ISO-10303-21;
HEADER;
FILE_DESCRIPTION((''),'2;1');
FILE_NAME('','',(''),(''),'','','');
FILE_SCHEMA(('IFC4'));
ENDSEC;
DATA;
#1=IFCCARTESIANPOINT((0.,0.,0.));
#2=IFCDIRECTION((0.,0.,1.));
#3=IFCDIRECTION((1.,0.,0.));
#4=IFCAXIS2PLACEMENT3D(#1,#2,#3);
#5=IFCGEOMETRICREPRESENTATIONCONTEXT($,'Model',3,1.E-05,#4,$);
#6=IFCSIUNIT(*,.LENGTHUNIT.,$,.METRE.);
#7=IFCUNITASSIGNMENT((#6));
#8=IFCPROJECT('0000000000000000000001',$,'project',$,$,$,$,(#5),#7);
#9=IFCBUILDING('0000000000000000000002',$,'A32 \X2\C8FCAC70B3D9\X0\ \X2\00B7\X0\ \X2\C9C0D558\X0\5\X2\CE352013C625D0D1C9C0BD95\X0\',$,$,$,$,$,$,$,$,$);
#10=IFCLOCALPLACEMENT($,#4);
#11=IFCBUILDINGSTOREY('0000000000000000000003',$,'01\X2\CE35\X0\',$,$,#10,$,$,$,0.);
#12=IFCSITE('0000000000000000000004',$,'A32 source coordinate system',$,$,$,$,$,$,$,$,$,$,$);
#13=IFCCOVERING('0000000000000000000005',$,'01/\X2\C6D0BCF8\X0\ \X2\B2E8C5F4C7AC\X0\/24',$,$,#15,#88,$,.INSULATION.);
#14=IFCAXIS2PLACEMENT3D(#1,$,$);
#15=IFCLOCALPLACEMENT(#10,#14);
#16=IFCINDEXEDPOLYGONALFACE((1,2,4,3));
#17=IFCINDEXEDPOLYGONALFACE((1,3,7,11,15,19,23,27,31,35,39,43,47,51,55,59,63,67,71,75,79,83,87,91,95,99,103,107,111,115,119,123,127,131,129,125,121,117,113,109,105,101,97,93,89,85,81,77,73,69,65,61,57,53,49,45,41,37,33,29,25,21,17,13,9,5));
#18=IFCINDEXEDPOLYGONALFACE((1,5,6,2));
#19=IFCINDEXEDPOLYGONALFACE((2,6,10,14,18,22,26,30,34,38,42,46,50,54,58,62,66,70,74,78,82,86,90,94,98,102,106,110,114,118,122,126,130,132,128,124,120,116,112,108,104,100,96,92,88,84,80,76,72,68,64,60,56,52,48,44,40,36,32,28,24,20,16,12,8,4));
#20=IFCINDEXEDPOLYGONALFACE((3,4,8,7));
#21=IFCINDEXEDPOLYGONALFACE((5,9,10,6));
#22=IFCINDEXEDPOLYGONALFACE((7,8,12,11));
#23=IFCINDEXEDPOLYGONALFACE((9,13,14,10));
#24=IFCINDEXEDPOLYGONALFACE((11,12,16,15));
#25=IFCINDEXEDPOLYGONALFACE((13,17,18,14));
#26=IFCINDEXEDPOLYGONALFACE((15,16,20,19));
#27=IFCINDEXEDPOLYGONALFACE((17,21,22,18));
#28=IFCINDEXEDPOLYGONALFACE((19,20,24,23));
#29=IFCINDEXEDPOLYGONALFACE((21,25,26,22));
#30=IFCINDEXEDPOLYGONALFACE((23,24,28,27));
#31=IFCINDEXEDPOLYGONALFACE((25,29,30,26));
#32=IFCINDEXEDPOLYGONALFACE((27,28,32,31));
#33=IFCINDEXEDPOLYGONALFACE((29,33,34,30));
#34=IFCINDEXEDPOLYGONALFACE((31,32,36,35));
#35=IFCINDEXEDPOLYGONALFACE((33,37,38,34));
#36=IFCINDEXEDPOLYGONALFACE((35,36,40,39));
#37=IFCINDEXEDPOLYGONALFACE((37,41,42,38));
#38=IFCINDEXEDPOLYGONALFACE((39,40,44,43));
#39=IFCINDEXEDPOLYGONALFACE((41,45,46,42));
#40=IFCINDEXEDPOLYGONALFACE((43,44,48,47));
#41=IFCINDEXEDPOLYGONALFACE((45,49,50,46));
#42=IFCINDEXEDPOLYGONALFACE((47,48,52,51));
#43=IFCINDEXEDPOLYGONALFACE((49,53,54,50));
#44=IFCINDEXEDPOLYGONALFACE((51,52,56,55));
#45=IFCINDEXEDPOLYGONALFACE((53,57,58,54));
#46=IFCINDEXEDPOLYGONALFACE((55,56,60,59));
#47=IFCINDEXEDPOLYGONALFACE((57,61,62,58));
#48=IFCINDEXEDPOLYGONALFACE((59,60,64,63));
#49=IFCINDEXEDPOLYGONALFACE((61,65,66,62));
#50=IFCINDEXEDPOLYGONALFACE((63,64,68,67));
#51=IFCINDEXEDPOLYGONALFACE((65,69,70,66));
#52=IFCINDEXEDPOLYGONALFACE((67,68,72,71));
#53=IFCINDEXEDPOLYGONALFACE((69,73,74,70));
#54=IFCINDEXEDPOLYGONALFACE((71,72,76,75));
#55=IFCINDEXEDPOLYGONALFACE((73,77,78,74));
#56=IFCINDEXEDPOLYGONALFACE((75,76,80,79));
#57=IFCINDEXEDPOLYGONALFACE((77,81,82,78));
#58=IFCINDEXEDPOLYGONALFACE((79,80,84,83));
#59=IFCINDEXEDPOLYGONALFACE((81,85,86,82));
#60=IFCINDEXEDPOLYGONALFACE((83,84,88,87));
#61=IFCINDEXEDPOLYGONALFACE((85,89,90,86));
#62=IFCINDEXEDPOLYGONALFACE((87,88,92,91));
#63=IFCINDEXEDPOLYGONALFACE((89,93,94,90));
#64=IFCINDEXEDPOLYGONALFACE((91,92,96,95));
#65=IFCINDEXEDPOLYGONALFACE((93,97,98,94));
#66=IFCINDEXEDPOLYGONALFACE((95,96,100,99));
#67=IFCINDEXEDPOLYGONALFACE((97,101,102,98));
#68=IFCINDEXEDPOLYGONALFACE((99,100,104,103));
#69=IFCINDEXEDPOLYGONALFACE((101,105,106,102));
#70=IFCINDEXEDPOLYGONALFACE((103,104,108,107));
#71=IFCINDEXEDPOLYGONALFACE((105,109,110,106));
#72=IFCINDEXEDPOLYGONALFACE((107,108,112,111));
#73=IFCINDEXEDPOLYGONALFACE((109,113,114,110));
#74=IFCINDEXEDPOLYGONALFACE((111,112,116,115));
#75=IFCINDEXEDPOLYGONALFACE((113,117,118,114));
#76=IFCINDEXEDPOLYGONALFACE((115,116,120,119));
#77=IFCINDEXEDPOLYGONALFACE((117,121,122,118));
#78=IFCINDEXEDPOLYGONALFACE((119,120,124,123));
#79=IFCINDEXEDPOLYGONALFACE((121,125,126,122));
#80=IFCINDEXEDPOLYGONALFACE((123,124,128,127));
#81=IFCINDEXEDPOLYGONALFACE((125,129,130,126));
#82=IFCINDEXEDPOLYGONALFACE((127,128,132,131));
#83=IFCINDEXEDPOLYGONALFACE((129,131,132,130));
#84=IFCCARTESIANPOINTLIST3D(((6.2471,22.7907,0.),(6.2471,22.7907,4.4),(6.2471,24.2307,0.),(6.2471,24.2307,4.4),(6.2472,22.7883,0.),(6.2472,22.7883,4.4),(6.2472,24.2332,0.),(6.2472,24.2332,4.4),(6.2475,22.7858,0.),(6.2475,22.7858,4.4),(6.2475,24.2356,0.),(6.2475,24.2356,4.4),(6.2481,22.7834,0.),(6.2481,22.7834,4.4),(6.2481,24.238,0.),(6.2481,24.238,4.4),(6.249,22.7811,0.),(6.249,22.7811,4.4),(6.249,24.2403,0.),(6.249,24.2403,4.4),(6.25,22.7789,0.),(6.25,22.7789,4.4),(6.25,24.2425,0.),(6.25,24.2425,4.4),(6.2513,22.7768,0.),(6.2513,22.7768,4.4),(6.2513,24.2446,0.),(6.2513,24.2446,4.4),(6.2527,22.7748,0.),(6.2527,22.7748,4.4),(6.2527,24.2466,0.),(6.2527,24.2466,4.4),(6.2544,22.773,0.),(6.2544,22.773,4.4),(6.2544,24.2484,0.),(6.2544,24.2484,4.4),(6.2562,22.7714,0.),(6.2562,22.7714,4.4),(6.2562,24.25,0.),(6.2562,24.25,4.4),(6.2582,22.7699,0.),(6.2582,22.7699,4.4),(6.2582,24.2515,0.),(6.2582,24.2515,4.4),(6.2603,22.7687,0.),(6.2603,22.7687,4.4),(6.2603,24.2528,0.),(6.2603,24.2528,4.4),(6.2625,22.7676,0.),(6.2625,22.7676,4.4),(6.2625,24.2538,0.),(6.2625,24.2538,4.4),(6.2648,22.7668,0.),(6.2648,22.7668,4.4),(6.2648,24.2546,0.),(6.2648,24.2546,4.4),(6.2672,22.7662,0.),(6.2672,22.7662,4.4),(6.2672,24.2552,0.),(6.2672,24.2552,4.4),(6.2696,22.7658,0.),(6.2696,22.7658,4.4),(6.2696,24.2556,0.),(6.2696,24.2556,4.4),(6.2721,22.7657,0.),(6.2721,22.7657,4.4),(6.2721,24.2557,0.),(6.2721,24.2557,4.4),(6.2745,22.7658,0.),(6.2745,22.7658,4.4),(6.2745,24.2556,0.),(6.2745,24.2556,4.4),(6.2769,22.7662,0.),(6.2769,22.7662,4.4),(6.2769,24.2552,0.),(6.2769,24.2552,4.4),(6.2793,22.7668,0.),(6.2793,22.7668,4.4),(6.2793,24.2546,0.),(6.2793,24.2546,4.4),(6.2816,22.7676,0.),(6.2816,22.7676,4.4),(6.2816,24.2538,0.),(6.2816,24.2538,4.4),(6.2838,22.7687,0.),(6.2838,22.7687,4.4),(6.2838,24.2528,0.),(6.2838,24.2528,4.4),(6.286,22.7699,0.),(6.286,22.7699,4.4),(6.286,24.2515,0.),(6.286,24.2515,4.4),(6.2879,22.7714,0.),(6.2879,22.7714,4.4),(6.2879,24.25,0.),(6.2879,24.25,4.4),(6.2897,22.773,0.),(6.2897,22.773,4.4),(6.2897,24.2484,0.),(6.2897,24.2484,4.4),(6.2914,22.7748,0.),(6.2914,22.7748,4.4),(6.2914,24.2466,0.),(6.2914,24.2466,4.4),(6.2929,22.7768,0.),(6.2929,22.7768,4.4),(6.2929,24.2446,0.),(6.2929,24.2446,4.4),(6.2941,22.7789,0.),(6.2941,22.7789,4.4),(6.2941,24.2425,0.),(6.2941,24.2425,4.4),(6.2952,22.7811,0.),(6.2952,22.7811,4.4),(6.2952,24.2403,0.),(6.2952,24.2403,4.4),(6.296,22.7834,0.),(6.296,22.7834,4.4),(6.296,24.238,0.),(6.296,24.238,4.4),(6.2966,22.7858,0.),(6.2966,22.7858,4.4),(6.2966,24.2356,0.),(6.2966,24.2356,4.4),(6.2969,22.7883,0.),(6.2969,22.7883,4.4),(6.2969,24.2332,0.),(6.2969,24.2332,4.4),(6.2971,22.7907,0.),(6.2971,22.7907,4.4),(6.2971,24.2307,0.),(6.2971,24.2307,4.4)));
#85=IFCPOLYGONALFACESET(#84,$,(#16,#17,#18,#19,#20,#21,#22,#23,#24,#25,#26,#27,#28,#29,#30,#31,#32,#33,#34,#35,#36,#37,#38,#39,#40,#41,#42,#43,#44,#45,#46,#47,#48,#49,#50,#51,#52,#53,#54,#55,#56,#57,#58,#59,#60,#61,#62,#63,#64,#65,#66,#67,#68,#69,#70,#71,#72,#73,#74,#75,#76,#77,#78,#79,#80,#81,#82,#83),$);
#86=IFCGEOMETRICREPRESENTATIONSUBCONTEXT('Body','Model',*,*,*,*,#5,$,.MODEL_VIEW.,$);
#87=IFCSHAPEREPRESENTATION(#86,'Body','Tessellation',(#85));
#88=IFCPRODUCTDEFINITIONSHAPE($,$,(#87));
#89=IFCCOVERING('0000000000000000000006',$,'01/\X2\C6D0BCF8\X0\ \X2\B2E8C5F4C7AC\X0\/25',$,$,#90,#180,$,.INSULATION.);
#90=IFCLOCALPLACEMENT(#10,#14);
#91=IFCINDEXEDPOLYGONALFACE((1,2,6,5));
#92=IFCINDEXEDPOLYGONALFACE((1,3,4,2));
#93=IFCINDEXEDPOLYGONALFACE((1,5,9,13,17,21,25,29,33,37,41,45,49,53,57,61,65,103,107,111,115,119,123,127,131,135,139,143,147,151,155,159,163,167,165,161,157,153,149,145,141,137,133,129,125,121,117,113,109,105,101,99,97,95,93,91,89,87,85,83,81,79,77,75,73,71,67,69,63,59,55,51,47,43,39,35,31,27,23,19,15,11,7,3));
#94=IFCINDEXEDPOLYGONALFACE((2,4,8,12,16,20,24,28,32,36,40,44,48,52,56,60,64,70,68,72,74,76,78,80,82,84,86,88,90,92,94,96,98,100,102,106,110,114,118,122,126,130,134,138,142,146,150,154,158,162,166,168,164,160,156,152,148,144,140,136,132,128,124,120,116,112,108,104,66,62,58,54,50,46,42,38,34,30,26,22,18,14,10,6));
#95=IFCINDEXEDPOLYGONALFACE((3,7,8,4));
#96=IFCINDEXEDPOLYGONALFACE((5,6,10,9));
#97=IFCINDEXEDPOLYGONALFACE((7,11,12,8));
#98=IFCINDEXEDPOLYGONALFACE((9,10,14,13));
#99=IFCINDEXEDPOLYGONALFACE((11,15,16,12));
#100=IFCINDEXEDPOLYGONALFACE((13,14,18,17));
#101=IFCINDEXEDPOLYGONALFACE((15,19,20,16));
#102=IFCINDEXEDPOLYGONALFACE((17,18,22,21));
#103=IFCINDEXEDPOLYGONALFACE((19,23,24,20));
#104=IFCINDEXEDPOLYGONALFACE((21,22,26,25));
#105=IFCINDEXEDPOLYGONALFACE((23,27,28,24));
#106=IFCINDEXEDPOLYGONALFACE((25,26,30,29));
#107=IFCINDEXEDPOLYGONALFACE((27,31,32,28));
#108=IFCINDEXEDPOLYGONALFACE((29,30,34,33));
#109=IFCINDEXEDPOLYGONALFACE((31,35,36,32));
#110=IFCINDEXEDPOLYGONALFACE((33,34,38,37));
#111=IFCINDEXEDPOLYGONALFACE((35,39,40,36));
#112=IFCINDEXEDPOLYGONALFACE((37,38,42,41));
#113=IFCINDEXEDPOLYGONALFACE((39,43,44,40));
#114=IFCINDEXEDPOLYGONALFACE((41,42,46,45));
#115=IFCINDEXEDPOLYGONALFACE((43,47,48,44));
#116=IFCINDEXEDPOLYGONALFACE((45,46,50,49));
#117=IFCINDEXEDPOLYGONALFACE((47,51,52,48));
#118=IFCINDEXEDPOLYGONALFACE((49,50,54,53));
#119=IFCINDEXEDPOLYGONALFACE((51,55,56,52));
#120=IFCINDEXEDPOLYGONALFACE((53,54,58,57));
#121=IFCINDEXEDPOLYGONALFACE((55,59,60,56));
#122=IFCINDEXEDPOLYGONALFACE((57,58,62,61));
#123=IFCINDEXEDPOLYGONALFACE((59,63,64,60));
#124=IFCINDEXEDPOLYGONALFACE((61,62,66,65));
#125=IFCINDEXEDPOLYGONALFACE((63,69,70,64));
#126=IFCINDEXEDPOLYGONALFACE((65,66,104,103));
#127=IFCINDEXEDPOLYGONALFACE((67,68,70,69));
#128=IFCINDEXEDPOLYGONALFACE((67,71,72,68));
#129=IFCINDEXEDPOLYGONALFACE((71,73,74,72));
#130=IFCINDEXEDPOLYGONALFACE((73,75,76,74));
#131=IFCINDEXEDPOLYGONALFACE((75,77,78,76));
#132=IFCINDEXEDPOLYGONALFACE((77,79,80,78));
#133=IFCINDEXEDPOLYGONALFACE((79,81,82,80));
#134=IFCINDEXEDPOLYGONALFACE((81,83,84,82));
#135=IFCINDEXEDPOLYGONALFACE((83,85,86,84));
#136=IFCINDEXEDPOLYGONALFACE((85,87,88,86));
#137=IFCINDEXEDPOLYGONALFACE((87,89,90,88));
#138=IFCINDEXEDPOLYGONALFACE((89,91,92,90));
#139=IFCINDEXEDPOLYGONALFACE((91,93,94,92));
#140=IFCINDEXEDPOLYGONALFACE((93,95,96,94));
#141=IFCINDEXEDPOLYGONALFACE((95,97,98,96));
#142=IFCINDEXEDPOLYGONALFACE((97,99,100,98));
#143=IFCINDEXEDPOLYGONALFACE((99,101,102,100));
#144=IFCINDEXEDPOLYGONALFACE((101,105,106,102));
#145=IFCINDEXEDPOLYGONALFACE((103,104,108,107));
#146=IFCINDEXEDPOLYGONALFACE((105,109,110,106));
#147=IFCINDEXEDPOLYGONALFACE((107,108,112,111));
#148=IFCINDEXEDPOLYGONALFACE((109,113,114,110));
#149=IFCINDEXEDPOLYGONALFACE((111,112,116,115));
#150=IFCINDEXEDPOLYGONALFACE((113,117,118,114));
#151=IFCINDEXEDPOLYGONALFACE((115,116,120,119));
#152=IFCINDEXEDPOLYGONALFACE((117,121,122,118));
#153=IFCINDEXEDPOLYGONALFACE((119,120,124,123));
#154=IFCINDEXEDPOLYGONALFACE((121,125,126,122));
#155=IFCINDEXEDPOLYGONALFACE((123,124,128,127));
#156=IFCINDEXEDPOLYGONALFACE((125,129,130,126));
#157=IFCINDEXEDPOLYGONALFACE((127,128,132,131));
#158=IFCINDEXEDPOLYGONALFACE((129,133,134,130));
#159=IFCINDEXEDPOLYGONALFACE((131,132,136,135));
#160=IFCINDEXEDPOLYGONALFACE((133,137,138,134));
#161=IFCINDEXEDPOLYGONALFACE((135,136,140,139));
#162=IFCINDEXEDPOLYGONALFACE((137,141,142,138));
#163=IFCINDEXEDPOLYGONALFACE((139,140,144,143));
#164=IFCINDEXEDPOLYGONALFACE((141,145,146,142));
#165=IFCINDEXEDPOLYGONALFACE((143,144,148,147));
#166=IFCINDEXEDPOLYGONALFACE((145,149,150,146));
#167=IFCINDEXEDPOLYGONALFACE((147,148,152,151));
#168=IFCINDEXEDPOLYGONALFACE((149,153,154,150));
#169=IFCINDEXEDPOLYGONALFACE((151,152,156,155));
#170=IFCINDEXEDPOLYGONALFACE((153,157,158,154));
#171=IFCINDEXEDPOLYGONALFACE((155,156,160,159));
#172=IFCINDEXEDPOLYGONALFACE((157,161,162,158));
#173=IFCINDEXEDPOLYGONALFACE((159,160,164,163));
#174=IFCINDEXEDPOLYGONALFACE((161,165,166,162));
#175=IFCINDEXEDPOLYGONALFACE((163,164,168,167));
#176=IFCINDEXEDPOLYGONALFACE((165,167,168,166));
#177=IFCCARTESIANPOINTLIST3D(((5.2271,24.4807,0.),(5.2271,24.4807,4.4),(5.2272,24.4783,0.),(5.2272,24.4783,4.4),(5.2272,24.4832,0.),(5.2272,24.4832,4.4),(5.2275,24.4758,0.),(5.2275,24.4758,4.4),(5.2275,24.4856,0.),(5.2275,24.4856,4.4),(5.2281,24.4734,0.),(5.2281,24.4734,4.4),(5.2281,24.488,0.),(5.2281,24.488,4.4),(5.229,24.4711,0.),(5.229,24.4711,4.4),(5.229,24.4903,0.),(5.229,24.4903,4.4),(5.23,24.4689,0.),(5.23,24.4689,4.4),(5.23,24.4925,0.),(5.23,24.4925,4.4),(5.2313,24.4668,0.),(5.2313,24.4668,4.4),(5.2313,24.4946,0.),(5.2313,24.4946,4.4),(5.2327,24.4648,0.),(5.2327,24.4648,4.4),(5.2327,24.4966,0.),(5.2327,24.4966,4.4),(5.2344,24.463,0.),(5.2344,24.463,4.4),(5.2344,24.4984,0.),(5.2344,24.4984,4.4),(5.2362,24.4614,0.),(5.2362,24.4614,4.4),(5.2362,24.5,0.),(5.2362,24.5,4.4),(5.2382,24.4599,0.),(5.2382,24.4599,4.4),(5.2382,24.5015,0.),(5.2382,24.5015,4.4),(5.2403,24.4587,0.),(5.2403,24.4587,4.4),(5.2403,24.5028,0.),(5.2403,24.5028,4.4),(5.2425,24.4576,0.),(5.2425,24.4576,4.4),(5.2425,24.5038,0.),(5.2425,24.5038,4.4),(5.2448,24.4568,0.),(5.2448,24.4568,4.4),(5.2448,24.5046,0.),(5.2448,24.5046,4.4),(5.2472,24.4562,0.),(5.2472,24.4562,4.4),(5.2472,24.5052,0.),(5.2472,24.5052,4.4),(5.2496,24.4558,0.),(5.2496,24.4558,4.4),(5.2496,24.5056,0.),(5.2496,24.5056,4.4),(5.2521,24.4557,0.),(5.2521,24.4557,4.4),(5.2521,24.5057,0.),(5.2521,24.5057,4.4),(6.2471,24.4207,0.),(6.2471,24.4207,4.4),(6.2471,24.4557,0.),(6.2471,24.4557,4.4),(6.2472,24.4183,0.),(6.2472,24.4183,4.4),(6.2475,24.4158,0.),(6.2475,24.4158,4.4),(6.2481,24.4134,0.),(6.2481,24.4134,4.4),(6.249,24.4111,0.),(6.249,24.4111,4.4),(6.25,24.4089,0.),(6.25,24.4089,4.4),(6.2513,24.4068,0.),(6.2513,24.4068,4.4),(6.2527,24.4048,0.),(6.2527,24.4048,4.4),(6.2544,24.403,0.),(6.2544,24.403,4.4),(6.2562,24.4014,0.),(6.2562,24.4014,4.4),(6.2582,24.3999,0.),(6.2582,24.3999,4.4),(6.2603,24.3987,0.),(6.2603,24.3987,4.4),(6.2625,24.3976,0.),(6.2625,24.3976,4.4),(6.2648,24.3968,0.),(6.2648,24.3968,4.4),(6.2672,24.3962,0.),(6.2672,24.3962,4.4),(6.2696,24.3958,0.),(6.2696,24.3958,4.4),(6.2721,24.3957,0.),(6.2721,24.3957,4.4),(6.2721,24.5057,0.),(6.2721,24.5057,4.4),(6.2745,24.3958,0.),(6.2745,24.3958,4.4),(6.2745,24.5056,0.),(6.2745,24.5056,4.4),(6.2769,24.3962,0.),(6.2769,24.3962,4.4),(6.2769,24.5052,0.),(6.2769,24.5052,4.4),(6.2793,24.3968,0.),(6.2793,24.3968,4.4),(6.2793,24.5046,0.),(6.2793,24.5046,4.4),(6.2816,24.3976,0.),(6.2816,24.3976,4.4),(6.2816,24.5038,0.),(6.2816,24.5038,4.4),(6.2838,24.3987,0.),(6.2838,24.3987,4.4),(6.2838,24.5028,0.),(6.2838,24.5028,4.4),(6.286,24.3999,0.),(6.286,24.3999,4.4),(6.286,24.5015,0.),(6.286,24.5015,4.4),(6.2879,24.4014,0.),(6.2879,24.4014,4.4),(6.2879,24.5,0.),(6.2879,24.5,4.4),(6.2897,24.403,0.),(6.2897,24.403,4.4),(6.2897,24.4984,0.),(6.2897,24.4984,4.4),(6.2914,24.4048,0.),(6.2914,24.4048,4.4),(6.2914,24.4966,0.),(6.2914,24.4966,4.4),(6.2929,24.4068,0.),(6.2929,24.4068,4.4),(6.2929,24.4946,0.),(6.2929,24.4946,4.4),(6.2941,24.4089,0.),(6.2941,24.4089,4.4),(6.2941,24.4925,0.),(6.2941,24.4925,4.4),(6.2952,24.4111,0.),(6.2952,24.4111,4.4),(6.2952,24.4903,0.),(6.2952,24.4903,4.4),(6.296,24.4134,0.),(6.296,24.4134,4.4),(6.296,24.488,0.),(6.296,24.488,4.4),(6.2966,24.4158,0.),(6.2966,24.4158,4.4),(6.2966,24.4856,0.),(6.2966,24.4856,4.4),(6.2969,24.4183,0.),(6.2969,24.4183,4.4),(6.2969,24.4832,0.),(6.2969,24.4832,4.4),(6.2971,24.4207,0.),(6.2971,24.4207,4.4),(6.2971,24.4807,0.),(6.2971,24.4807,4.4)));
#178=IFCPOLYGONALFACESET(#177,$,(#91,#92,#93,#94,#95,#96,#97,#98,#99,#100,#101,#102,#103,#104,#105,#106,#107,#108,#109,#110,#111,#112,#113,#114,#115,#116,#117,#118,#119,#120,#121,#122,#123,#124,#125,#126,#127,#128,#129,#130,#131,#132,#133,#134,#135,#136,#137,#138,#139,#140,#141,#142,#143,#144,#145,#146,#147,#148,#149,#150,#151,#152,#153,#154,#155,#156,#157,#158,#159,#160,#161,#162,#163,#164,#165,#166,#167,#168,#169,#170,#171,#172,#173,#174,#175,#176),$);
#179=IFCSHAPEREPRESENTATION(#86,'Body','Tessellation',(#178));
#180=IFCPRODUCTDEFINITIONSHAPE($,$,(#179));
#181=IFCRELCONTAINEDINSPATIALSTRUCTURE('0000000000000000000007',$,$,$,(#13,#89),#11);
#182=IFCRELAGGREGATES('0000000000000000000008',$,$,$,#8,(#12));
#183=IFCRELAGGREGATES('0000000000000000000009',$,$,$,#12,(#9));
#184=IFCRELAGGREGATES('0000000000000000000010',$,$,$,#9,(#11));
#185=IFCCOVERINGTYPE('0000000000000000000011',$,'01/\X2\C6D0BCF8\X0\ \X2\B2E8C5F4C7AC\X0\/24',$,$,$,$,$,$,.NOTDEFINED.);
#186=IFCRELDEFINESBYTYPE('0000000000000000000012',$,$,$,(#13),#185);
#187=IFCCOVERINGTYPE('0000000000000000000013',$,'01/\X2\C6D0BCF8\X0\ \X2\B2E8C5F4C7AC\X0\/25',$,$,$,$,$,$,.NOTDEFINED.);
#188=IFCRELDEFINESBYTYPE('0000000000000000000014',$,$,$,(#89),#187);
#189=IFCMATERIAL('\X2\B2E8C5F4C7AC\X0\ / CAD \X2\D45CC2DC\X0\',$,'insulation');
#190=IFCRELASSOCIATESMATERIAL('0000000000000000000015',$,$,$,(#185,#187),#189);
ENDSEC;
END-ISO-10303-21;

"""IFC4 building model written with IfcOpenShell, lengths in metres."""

from ifc_helpers import new_model, si_unit, origin, origin_with_axes, place, context, subcontext, project, spatial, polyline, outline, extrude, source, transform, mapped, material, type_object, type_shapes, element, save


model = new_model("IFC4")

# Units and contexts
model_context = context("Model", 3, precision=1e-05, world=origin_with_axes())
body_context = subcontext(model_context, "Body", "Model", "MODEL_VIEW")
ifc_project = project(units=[si_unit("LENGTHUNIT", "METRE")], contexts=[model_context])

# Site, building, storey
site = spatial("IfcSite", under=ifc_project, Name="A32 source coordinate system")
building = spatial("IfcBuilding", under=site, Name="A32 주거동 · 지하5층–옥탑지붕")
storey_placement = place(None, origin_with_axes())
storey = spatial("IfcBuildingStorey", under=building, at=storey_placement, Name="01층", Elevation=0.0)

# Coverings
ifc_material = material(Name="단열재 / CAD 표시", Category="insulation")
covering_type_1 = type_object("IfcCoveringType", Name="01/원본 단열재/24", PredefinedType="NOTDEFINED", material=ifc_material)
shared_shape_1 = source(origin(), body_context, "Body", "SweptSolid", [
    extrude(outline(polyline([(6.2513, 24.2446), (6.2527, 24.2466), (6.2544, 24.2484), (6.2562, 24.25), (6.2582, 24.2515), (6.2603, 24.2528), (6.2625, 24.2538), (6.2648, 24.2546), (6.2672, 24.2552), (6.2696, 24.2556), (6.2721, 24.2557), (6.2745, 24.2556), (6.2769, 24.2552), (6.2793, 24.2546), (6.2816, 24.2538), (6.2838, 24.2528), (6.286, 24.2515), (6.2879, 24.25), (6.2897, 24.2484), (6.2914, 24.2466), (6.2929, 24.2446), (6.2941, 24.2425), (6.2952, 24.2403), (6.296, 24.238), (6.2966, 24.2356), (6.2969, 24.2332), (6.2971, 24.2307), (6.2971, 22.7907), (6.2969, 22.7883), (6.2966, 22.7858), (6.296, 22.7834), (6.2952, 22.7811), (6.2941, 22.7789), (6.2929, 22.7768), (6.2914, 22.7748), (6.2897, 22.773), (6.2879, 22.7714), (6.286, 22.7699), (6.2838, 22.7687), (6.2816, 22.7676), (6.2793, 22.7668), (6.2769, 22.7662), (6.2745, 22.7658), (6.2721, 22.7657), (6.2696, 22.7658), (6.2672, 22.7662), (6.2648, 22.7668), (6.2625, 22.7676), (6.2603, 22.7687), (6.2582, 22.7699), (6.2562, 22.7714), (6.2544, 22.773), (6.2527, 22.7748), (6.2513, 22.7768), (6.25, 22.7789), (6.249, 22.7811), (6.2481, 22.7834), (6.2475, 22.7858), (6.2472, 22.7883), (6.2471, 22.7907), (6.2471, 24.2307), (6.2472, 24.2332), (6.2475, 24.2356), (6.2481, 24.238), (6.249, 24.2403), (6.25, 24.2425), (6.2513, 24.2446)])), origin(), (0.0, 0.0, 1.0), 4.4),
])
type_shapes(covering_type_1, [shared_shape_1])
covering_1_placement = place(storey_placement, origin_with_axes())
element("IfcCovering", 1, at=covering_1_placement, inside=storey, type_object=covering_type_1, Name="01/원본 단열재/24", PredefinedType="INSULATION", context=body_context, shape_type="MappedRepresentation", body=[
    mapped(shared_shape_1, transform((0.0, 0.0, 0.0), scale=1.0)),
])
covering_type_2 = type_object("IfcCoveringType", Name="01/원본 단열재/25", PredefinedType="NOTDEFINED", material=ifc_material)
shared_shape_2 = source(origin(), body_context, "Body", "SweptSolid", [
    extrude(outline(polyline([(5.2382, 24.4599), (5.2362, 24.4614), (5.2344, 24.463), (5.2327, 24.4648), (5.2313, 24.4668), (5.23, 24.4689), (5.229, 24.4711), (5.2281, 24.4734), (5.2275, 24.4758), (5.2272, 24.4783), (5.2271, 24.4807), (5.2272, 24.4832), (5.2275, 24.4856), (5.2281, 24.488), (5.229, 24.4903), (5.23, 24.4925), (5.2313, 24.4946), (5.2327, 24.4966), (5.2344, 24.4984), (5.2362, 24.5), (5.2382, 24.5015), (5.2403, 24.5028), (5.2425, 24.5038), (5.2448, 24.5046), (5.2472, 24.5052), (5.2496, 24.5056), (5.2521, 24.5057), (6.2721, 24.5057), (6.2745, 24.5056), (6.2769, 24.5052), (6.2793, 24.5046), (6.2816, 24.5038), (6.2838, 24.5028), (6.286, 24.5015), (6.2879, 24.5), (6.2897, 24.4984), (6.2914, 24.4966), (6.2929, 24.4946), (6.2941, 24.4925), (6.2952, 24.4903), (6.296, 24.488), (6.2966, 24.4856), (6.2969, 24.4832), (6.2971, 24.4807), (6.2971, 24.4207), (6.2969, 24.4183), (6.2966, 24.4158), (6.296, 24.4134), (6.2952, 24.4111), (6.2941, 24.4089), (6.2929, 24.4068), (6.2914, 24.4048), (6.2897, 24.403), (6.2879, 24.4014), (6.286, 24.3999), (6.2838, 24.3987), (6.2816, 24.3976), (6.2793, 24.3968), (6.2769, 24.3962), (6.2745, 24.3958), (6.2721, 24.3957), (6.2696, 24.3958), (6.2672, 24.3962), (6.2648, 24.3968), (6.2625, 24.3976), (6.2603, 24.3987), (6.2582, 24.3999), (6.2562, 24.4014), (6.2544, 24.403), (6.2527, 24.4048), (6.2513, 24.4068), (6.25, 24.4089), (6.249, 24.4111), (6.2481, 24.4134), (6.2475, 24.4158), (6.2472, 24.4183), (6.2471, 24.4207), (6.2471, 24.4557), (5.2521, 24.4557), (5.2496, 24.4558), (5.2472, 24.4562), (5.2448, 24.4568), (5.2425, 24.4576), (5.2403, 24.4587), (5.2382, 24.4599)])), origin(), (0.0, 0.0, 1.0), 4.4),
])
type_shapes(covering_type_2, [shared_shape_2])
covering_2_placement = place(storey_placement, origin_with_axes())
element("IfcCovering", 2, at=covering_2_placement, inside=storey, type_object=covering_type_2, Name="01/원본 단열재/25", PredefinedType="INSULATION", context=body_context, shape_type="MappedRepresentation", body=[
    mapped(shared_shape_2, transform((0.0, 0.0, 0.0), scale=1.0)),
])

save(model, "model.ifc")
